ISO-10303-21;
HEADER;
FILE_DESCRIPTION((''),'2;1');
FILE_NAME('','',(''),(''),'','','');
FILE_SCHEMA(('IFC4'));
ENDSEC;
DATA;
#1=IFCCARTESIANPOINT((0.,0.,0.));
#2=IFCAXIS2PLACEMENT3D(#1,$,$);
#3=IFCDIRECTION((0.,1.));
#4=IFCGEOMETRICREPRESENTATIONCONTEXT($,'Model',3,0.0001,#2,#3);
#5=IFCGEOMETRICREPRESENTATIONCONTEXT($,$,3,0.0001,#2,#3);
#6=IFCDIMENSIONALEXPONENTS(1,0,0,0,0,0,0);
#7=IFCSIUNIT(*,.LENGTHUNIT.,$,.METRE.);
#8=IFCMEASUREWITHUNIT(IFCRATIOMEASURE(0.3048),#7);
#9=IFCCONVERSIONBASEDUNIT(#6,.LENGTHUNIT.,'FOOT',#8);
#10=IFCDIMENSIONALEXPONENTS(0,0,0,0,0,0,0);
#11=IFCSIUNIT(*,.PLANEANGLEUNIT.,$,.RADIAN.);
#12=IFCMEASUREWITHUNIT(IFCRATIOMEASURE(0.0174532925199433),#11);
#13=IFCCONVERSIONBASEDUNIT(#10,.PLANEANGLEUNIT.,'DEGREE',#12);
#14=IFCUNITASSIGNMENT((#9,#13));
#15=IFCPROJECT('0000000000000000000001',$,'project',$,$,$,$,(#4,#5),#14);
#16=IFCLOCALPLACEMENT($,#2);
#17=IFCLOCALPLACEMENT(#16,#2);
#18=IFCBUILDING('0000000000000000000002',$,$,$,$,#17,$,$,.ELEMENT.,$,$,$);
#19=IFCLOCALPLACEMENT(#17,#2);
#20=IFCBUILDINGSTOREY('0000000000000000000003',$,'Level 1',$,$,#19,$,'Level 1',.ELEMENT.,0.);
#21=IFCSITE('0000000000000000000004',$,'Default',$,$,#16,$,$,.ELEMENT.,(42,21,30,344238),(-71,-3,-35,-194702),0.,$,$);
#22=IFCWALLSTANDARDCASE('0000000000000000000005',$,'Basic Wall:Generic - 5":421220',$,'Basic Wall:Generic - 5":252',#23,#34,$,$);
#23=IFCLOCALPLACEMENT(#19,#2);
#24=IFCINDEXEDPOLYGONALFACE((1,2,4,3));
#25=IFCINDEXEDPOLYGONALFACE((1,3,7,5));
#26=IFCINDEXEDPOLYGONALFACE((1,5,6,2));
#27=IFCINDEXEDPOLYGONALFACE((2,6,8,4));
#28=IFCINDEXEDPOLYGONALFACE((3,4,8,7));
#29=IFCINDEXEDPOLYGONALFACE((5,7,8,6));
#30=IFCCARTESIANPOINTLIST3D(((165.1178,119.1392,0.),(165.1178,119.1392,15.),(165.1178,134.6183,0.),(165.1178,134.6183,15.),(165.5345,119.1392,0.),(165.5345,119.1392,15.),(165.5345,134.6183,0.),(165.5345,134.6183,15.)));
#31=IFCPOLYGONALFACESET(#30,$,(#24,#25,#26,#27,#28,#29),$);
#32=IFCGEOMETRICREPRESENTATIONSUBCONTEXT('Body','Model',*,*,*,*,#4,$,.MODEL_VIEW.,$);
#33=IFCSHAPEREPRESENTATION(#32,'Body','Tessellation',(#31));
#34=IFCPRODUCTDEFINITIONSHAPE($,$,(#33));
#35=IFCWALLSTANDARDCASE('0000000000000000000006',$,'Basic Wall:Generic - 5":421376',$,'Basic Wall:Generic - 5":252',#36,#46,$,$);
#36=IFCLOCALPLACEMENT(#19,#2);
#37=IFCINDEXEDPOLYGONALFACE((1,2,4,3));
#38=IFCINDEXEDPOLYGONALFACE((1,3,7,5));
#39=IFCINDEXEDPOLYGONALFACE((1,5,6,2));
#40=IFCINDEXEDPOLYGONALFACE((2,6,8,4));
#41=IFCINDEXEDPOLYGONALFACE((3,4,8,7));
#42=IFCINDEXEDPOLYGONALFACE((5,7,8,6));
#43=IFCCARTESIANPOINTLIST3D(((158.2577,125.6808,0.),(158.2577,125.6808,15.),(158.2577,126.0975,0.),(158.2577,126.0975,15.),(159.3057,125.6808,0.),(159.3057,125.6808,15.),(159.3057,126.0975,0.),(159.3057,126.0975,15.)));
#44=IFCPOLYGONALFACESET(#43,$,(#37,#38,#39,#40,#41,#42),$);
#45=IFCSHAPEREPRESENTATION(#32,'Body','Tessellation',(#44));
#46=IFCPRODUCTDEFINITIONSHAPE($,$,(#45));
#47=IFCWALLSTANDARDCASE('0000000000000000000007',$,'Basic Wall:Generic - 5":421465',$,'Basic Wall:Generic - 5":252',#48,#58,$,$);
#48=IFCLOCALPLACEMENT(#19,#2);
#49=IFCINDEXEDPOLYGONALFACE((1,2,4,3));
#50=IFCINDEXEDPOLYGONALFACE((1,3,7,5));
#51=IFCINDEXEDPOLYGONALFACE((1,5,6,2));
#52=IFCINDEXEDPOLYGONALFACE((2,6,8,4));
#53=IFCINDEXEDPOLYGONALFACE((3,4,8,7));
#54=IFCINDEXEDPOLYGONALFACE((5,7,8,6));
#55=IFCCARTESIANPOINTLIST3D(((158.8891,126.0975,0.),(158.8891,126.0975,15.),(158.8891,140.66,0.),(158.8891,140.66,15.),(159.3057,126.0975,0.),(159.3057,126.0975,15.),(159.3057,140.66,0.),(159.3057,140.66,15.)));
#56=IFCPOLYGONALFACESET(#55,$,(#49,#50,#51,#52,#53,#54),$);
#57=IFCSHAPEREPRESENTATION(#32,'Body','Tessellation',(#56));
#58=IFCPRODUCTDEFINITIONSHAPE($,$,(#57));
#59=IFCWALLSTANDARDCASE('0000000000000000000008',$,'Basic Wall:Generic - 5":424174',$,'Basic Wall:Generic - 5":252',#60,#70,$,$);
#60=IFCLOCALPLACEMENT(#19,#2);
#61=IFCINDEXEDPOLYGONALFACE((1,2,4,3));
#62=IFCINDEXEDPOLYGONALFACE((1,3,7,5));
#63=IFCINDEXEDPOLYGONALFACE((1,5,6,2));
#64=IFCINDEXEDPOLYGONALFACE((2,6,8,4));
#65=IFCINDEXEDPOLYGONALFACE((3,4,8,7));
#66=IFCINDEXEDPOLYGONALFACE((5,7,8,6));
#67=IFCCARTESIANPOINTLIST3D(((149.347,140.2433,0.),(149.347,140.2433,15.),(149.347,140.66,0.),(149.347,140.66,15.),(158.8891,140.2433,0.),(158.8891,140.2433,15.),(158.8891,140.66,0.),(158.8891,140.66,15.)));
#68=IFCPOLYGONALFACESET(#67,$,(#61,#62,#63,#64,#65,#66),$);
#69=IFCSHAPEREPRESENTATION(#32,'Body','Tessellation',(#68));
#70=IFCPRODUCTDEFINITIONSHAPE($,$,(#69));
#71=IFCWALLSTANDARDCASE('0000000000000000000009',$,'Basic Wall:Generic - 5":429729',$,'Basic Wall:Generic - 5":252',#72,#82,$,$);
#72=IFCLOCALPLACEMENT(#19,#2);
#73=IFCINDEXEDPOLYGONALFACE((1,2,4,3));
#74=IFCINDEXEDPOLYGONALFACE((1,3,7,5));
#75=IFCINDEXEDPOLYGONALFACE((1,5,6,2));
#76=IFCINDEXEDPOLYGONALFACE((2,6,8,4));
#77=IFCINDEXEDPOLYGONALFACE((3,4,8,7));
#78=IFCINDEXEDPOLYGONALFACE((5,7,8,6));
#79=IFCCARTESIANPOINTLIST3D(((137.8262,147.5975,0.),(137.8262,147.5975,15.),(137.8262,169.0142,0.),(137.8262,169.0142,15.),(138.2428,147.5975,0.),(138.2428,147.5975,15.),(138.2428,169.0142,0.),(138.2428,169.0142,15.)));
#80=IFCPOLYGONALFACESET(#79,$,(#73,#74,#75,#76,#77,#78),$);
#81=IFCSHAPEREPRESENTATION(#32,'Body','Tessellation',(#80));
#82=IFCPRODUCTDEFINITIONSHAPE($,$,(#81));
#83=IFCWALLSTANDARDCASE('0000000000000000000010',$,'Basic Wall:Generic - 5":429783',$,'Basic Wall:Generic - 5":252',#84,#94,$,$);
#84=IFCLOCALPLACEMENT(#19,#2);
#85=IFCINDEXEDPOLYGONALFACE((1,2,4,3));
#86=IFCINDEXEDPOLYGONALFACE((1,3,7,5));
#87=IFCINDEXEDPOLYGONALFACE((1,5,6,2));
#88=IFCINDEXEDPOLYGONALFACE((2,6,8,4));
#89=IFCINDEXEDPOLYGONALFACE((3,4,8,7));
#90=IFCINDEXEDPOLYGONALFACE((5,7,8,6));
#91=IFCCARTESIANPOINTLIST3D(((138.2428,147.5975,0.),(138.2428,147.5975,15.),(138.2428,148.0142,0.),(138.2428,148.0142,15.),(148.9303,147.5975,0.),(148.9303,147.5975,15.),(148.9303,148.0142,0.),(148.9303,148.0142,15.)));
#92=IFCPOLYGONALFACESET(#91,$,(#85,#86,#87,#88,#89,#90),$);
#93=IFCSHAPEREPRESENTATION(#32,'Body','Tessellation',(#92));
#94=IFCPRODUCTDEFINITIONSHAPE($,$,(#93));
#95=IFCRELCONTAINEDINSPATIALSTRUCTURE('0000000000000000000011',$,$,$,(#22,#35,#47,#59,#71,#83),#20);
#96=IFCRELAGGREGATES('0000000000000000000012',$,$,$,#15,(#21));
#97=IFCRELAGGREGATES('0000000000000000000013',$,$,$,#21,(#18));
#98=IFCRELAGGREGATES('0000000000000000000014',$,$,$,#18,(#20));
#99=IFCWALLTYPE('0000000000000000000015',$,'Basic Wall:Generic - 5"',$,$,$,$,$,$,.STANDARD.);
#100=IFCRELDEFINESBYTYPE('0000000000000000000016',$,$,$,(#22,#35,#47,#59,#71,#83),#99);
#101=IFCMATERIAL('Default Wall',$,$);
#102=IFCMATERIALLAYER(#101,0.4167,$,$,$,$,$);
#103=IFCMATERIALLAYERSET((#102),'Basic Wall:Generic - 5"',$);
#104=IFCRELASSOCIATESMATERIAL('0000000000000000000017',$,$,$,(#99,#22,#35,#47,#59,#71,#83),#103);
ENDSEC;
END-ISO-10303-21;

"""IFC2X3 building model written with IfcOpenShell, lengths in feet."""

from ifc_helpers import new_model, entity, si_unit, converted_unit, direction, frame, frame_2d, origin, place, context, subcontext, project, spatial, rectangle, extrude, material, layer, layer_set, layer_usage, type_object, element, save


model = new_model("IFC2X3")

# Units and contexts
model_context = context("Model", 3, precision=0.0001, world=origin(), true_north=direction((0.0, 1.0)))
context_of_model = context(None, 3, precision=0.0001, world=origin(), true_north=direction((0.0, 1.0)))
body_context = subcontext(model_context, "Body", "Model", "MODEL_VIEW")
ifc_project = project(units=[converted_unit("LENGTHUNIT", "FOOT", entity("IfcRatioMeasure", 0.3048), si_unit("LENGTHUNIT", "METRE"), dimensions=[1, 0, 0, 0, 0, 0, 0]), converted_unit("PLANEANGLEUNIT", "DEGREE", entity("IfcRatioMeasure", 0.0174532925199433), si_unit("PLANEANGLEUNIT", "RADIAN"), dimensions=[0, 0, 0, 0, 0, 0, 0])], contexts=[model_context, context_of_model])

# Site, building, storey
site_placement = place(None, origin())
site = spatial("IfcSite", under=ifc_project, at=site_placement, Name="Default", CompositionType="ELEMENT", RefLatitude=(42, 21, 30, 344238), RefLongitude=(-71, -3, -35, -194702), RefElevation=0.0)
building_placement = place(site_placement, origin())
building = spatial("IfcBuilding", under=site, at=building_placement, CompositionType="ELEMENT")
storey_placement = place(building_placement, origin())
storey = spatial("IfcBuildingStorey", under=building, at=storey_placement, Name="Level 1", LongName="Level 1", CompositionType="ELEMENT", Elevation=0.0)

# Shared definitions
ifc_material_1 = material(Name="Default Wall")

# Shared definitions
ifc_layer_1 = layer(ifc_material_1, 0.4167)
ifc_layer_set_1 = layer_set([ifc_layer_1], Name="Basic Wall:Generic - 5\"")
wall_type_1 = type_object("IfcWallType", Name="Basic Wall:Generic - 5\"", PredefinedType="STANDARD", material=ifc_layer_set_1)

# Walls
ifc_layer_usage_1 = layer_usage(ifc_layer_set_1, "AXIS2", "NEGATIVE", 0.2083)
wall_1_placement = place(storey_placement, frame((165.3262, 134.6183, 0.0), z_axis=(0.0, 0.0, 1.0), x_axis=(0.0, -1.0, 0.0)))
element("IfcWallStandardCase", 1, at=wall_1_placement, inside=storey, type_object=wall_type_1, material=ifc_layer_usage_1, Name="Basic Wall:Generic - 5\":421220", ObjectType="Basic Wall:Generic - 5\":252", context=body_context, shape_type="SweptSolid", body=[
    extrude(rectangle(XDim=15.4792, YDim=0.4167, at=frame_2d((7.7396, 0.0), x_axis=(-1.0, 0.0))), origin(), (0.0, 0.0, 1.0), 15.0),
])
ifc_layer_usage_2 = layer_usage(ifc_layer_set_1, "AXIS2", "NEGATIVE", 0.2083)
wall_2_placement = place(storey_placement, frame((158.2577, 125.8892, 0.0)))
element("IfcWallStandardCase", 2, at=wall_2_placement, inside=storey, type_object=wall_type_1, material=ifc_layer_usage_2, Name="Basic Wall:Generic - 5\":421376", ObjectType="Basic Wall:Generic - 5\":252", context=body_context, shape_type="SweptSolid", body=[
    extrude(rectangle(XDim=1.048, YDim=0.4167, at=frame_2d((0.524, 0.0), x_axis=(-1.0, 0.0))), origin(), (0.0, 0.0, 1.0), 15.0),
])
ifc_layer_usage_3 = layer_usage(ifc_layer_set_1, "AXIS2", "NEGATIVE", 0.2083)
wall_3_placement = place(storey_placement, frame((159.0974, 126.0975, 0.0), z_axis=(0.0, 0.0, 1.0), x_axis=(0.0, 1.0, 0.0)))
element("IfcWallStandardCase", 3, at=wall_3_placement, inside=storey, type_object=wall_type_1, material=ifc_layer_usage_3, Name="Basic Wall:Generic - 5\":421465", ObjectType="Basic Wall:Generic - 5\":252", context=body_context, shape_type="SweptSolid", body=[
    extrude(rectangle(XDim=14.5625, YDim=0.4167, at=frame_2d((7.2812, 0.0), x_axis=(-1.0, 0.0))), origin(), (0.0, 0.0, 1.0), 15.0),
])
ifc_layer_usage_4 = layer_usage(ifc_layer_set_1, "AXIS2", "NEGATIVE", 0.2083)
wall_4_placement = place(storey_placement, frame((158.8891, 140.4517, 0.0), z_axis=(0.0, 0.0, 1.0), x_axis=(-1.0, 0.0, 0.0)))
element("IfcWallStandardCase", 4, at=wall_4_placement, inside=storey, type_object=wall_type_1, material=ifc_layer_usage_4, Name="Basic Wall:Generic - 5\":424174", ObjectType="Basic Wall:Generic - 5\":252", context=body_context, shape_type="SweptSolid", body=[
    extrude(rectangle(XDim=9.542, YDim=0.4167, at=frame_2d((4.771, 0.0), x_axis=(-1.0, 0.0))), origin(), (0.0, 0.0, 1.0), 15.0),
])
ifc_layer_usage_5 = layer_usage(ifc_layer_set_1, "AXIS2", "NEGATIVE", 0.2083)
wall_5_placement = place(storey_placement, frame((138.0345, 147.5975, 0.0), z_axis=(0.0, 0.0, 1.0), x_axis=(0.0, 1.0, 0.0)))
element("IfcWallStandardCase", 5, at=wall_5_placement, inside=storey, type_object=wall_type_1, material=ifc_layer_usage_5, Name="Basic Wall:Generic - 5\":429729", ObjectType="Basic Wall:Generic - 5\":252", context=body_context, shape_type="SweptSolid", body=[
    extrude(rectangle(XDim=21.4167, YDim=0.4167, at=frame_2d((10.7083, 0.0), x_axis=(-1.0, 0.0))), origin(), (0.0, 0.0, 1.0), 15.0),
])
ifc_layer_usage_6 = layer_usage(ifc_layer_set_1, "AXIS2", "NEGATIVE", 0.2083)
wall_6_placement = place(storey_placement, frame((148.9303, 147.8058, 0.0), z_axis=(0.0, 0.0, 1.0), x_axis=(-1.0, 0.0, 0.0)))
element("IfcWallStandardCase", 6, at=wall_6_placement, inside=storey, type_object=wall_type_1, material=ifc_layer_usage_6, Name="Basic Wall:Generic - 5\":429783", ObjectType="Basic Wall:Generic - 5\":252", context=body_context, shape_type="SweptSolid", body=[
    extrude(rectangle(XDim=10.6875, YDim=0.4167, at=frame_2d((5.3438, 0.0), x_axis=(-1.0, 0.0))), origin(), (0.0, 0.0, 1.0), 15.0),
])

save(model, "model.ifc")
